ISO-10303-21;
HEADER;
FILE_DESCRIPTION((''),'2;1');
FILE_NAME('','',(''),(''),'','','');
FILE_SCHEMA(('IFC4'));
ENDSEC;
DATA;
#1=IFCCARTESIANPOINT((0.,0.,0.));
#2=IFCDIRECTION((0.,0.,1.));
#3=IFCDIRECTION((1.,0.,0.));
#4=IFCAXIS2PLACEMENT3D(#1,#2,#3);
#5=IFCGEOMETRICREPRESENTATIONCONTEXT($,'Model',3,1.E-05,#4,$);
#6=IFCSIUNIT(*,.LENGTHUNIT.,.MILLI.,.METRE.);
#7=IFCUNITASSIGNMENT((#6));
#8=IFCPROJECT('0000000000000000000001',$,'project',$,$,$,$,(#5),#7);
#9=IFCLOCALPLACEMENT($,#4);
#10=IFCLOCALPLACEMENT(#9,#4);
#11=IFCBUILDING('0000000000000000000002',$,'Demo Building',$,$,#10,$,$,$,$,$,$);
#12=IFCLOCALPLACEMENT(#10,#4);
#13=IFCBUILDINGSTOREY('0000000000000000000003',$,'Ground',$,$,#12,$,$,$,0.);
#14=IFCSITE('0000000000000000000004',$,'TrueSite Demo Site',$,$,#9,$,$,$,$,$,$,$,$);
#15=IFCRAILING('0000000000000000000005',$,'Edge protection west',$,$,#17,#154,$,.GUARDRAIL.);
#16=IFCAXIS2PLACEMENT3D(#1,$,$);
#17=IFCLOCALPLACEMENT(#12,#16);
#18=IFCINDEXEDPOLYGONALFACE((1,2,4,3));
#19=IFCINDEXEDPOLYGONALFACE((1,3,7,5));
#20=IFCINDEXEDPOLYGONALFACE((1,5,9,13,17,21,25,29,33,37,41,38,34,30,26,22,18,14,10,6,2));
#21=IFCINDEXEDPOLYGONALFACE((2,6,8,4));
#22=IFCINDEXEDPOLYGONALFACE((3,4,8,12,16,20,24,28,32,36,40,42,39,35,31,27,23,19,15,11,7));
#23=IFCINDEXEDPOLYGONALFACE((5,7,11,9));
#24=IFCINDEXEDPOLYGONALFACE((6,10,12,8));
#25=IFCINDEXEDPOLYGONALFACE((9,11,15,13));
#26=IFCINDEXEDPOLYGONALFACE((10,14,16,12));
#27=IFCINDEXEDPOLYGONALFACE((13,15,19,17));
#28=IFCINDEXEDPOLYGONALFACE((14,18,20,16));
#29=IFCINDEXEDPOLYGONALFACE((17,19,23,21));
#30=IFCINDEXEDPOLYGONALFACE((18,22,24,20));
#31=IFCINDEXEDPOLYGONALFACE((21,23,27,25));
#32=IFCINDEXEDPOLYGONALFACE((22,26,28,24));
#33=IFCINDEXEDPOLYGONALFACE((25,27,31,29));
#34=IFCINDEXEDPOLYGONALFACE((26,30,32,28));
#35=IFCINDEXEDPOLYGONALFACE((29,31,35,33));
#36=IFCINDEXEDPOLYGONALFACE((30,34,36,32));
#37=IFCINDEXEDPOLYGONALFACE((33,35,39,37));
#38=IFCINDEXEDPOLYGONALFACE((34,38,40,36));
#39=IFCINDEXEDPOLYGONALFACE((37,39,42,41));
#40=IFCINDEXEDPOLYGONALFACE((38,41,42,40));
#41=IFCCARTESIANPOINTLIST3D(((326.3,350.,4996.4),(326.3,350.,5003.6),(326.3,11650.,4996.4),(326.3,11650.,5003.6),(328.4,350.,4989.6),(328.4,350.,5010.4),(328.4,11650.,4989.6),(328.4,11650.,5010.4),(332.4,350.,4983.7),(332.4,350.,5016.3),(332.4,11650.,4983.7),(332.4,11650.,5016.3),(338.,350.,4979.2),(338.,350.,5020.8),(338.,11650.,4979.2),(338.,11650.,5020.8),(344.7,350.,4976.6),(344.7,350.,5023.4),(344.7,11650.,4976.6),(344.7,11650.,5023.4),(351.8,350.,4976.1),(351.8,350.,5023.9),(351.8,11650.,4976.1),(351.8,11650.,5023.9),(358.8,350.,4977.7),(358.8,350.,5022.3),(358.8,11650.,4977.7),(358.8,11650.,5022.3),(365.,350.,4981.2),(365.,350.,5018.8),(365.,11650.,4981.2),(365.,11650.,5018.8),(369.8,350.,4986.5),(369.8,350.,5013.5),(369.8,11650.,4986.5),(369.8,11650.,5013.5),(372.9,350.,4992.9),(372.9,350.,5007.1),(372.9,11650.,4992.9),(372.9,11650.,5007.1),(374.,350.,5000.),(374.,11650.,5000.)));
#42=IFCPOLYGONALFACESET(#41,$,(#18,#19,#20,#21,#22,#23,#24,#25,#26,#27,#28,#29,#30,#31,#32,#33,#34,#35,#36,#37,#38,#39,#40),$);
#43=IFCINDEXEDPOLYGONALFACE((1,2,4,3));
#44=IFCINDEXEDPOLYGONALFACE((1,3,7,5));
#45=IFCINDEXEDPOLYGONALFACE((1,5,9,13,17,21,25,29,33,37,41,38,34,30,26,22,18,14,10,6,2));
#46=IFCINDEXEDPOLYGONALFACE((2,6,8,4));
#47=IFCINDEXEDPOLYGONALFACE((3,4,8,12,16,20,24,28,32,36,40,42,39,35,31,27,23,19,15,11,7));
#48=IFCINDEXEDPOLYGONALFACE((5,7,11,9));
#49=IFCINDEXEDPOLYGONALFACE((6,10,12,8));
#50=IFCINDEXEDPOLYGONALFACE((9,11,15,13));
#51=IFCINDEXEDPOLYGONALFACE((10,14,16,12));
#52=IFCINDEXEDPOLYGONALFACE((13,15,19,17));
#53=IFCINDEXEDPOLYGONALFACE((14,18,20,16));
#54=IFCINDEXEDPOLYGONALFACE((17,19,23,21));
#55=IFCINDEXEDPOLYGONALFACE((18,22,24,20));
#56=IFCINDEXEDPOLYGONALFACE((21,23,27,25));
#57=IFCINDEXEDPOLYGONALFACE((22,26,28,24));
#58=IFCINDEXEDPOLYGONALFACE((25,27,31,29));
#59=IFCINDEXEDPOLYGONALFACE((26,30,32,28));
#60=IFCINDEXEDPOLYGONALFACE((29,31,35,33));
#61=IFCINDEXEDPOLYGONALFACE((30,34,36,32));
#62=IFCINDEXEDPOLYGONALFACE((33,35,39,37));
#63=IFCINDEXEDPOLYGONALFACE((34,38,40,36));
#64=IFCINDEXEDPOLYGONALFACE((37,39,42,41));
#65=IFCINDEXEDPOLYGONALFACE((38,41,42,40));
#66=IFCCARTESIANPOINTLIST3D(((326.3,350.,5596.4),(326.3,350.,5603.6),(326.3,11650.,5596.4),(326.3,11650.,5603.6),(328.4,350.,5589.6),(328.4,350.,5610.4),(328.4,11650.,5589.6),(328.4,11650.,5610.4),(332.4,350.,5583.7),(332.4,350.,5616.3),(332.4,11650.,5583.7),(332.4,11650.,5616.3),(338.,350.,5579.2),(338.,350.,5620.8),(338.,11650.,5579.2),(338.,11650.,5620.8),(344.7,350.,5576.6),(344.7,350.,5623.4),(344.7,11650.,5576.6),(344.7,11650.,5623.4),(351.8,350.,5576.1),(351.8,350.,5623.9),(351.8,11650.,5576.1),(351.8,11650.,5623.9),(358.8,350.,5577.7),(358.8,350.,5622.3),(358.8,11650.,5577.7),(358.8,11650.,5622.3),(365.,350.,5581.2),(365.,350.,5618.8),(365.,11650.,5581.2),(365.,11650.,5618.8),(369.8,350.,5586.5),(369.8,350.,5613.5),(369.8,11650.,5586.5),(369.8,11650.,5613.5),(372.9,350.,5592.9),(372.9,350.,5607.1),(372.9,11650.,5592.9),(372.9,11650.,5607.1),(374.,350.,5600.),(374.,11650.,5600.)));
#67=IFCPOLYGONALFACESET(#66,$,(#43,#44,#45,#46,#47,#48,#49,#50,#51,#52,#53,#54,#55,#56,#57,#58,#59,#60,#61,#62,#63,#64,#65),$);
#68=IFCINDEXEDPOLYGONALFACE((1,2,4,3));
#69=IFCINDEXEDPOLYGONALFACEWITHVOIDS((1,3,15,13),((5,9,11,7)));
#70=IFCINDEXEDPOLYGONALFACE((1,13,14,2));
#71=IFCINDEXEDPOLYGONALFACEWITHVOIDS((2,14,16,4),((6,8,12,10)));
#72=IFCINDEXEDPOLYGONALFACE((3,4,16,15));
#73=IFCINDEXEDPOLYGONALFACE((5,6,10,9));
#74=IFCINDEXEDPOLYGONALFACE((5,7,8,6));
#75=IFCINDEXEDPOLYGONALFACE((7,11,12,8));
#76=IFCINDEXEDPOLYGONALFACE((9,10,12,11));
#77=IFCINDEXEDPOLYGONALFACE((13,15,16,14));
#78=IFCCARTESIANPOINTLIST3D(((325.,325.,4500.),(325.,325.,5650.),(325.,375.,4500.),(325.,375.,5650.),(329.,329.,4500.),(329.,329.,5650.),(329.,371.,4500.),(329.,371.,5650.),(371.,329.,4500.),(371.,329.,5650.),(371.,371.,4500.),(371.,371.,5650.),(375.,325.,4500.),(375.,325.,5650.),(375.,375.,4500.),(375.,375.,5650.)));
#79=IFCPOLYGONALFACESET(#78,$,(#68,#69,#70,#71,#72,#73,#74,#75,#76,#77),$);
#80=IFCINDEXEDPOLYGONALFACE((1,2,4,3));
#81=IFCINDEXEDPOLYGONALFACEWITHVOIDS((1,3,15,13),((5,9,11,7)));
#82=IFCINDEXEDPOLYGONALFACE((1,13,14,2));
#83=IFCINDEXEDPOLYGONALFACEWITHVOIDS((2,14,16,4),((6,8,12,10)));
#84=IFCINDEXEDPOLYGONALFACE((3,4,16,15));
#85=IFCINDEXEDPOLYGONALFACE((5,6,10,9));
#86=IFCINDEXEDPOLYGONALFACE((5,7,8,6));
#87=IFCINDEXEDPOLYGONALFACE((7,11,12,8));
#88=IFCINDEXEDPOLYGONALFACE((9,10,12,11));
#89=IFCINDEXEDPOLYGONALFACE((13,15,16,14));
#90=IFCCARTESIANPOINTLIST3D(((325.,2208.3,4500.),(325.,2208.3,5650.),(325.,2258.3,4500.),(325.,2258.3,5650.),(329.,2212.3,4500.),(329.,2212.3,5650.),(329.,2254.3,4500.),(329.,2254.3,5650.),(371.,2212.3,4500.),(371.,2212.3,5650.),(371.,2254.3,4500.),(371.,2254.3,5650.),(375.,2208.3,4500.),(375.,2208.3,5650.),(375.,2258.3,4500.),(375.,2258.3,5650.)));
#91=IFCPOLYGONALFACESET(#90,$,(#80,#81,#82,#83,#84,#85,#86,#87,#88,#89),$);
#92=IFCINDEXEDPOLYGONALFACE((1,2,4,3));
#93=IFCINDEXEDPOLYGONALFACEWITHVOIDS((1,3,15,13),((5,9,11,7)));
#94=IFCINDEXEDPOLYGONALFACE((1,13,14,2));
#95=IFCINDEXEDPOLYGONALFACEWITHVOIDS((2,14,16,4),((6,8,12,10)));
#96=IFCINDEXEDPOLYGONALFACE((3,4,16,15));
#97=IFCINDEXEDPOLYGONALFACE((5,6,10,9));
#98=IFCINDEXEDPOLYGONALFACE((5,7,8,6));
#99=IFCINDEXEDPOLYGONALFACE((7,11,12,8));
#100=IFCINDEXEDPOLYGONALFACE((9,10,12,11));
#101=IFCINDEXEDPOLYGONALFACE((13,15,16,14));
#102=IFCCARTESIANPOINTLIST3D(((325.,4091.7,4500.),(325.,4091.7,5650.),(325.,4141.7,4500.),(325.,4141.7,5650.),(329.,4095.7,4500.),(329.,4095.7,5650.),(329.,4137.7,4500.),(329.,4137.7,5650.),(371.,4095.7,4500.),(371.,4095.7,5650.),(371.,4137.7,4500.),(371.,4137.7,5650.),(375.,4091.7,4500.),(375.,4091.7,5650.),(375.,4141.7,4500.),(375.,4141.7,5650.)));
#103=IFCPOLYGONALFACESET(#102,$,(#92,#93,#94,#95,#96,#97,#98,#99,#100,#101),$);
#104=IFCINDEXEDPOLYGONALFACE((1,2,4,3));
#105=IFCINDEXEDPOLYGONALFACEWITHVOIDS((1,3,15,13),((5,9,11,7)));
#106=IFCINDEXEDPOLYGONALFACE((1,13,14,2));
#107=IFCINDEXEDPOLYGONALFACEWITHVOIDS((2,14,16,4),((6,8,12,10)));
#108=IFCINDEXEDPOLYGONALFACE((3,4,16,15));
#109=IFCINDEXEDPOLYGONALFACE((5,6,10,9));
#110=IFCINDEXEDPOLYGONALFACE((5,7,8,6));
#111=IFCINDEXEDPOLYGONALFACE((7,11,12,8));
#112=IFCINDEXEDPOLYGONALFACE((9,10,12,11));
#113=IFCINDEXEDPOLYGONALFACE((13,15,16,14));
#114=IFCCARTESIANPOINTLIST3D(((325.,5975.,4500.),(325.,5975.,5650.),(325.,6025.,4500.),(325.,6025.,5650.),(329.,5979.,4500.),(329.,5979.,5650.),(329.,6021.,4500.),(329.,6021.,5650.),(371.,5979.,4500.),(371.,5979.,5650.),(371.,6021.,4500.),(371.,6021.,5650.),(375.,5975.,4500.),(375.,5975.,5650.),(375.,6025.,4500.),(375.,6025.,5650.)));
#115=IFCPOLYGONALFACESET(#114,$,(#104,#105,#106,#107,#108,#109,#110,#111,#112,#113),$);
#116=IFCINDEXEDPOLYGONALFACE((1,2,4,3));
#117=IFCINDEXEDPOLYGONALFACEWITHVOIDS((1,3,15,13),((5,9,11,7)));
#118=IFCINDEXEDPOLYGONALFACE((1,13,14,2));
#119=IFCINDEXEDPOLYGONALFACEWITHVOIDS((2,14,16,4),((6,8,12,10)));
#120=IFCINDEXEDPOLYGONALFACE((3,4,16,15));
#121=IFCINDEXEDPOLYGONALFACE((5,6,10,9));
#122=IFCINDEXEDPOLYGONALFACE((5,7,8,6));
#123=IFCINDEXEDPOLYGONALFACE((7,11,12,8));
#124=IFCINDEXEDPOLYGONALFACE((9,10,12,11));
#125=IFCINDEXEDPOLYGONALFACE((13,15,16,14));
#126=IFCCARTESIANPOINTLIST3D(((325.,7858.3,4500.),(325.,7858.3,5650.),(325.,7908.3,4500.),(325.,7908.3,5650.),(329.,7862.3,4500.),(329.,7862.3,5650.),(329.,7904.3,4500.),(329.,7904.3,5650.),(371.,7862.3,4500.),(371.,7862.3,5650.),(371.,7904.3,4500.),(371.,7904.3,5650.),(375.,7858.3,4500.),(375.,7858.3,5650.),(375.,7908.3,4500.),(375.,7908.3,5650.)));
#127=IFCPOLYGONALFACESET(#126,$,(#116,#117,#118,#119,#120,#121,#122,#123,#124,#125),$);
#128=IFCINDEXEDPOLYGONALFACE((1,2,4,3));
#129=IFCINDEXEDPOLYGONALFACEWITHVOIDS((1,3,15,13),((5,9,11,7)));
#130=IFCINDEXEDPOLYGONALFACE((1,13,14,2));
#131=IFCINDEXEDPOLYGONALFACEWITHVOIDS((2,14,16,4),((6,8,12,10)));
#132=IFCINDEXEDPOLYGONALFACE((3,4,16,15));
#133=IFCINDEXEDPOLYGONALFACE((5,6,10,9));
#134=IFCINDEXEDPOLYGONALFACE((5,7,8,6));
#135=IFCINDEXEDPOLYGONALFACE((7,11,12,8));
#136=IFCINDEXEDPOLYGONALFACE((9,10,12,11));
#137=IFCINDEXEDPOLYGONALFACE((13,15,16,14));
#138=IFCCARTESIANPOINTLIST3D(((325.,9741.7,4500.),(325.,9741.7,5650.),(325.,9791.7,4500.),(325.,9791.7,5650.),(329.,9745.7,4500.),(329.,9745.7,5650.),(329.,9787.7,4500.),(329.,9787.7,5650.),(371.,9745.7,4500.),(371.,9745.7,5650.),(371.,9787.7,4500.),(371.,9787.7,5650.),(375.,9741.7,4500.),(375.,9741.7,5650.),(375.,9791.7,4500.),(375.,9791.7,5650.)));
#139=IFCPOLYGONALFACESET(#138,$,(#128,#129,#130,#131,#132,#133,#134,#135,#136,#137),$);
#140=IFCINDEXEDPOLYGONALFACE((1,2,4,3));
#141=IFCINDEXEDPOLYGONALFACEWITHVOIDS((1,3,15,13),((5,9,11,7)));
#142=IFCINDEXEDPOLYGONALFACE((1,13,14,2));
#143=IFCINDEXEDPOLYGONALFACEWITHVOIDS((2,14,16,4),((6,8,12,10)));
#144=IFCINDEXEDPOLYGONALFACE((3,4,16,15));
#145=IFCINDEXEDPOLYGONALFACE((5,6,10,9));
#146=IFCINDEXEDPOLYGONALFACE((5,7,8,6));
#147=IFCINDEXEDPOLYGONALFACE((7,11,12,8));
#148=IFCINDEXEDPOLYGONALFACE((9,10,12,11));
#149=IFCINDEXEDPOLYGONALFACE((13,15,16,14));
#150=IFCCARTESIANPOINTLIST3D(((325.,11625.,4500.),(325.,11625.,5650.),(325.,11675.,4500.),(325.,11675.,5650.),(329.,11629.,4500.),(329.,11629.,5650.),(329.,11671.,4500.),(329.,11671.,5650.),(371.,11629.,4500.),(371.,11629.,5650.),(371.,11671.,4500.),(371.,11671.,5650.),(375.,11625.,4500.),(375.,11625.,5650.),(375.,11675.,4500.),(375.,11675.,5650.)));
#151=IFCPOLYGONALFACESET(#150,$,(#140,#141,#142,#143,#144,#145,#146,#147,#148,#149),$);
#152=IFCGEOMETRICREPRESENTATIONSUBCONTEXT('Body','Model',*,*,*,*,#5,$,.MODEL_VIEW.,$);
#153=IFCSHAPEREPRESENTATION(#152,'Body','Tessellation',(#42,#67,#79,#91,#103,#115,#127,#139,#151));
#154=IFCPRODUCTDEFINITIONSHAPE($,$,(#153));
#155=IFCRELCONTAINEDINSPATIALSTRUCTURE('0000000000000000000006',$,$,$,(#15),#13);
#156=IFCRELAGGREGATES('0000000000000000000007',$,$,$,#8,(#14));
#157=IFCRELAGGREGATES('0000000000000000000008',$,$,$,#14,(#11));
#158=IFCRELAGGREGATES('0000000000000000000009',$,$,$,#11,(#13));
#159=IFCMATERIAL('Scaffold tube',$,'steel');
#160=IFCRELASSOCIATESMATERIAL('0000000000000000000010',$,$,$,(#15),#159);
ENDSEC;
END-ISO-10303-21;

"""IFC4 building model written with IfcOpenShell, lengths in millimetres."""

from ifc_helpers import new_model, si_unit, frame, origin_with_axes, place, context, subcontext, project, spatial, hollow_rectangle, circle, extrude, material, element, save


model = new_model("IFC4")

# Units and contexts
model_context = context("Model", 3, precision=1e-05, world=origin_with_axes())
body_context = subcontext(model_context, "Body", "Model", "MODEL_VIEW")
ifc_project = project(units=[si_unit("LENGTHUNIT", "METRE", prefix="MILLI")], contexts=[model_context])

# Site, building, storey
site_placement = place(None, origin_with_axes())
site = spatial("IfcSite", under=ifc_project, at=site_placement, Name="TrueSite Demo Site")
building_placement = place(site_placement, origin_with_axes())
building = spatial("IfcBuilding", under=site, at=building_placement, Name="Demo Building")
storey_placement = place(building_placement, origin_with_axes())
storey = spatial("IfcBuildingStorey", under=building, at=storey_placement, Name="Ground", Elevation=0.0)

# Railing
ifc_material_1 = material(Name="Scaffold tube", Category="steel")
railing_1_placement = place(storey_placement, origin_with_axes())
element("IfcRailing", 1, at=railing_1_placement, inside=storey, material=ifc_material_1, Name="Edge protection west", PredefinedType="GUARDRAIL", context=body_context, shape_type="SweptSolid", body=[
    extrude(circle(Radius=24.0), frame((350.0, 350.0, 5000.0), z_axis=(0.0, 1.0, 0.0), x_axis=(1.0, 0.0, 0.0)), (0.0, 0.0, 1.0), 11300.0),
    extrude(circle(Radius=24.0), frame((350.0, 350.0, 5600.0), z_axis=(0.0, 1.0, 0.0), x_axis=(1.0, 0.0, 0.0)), (0.0, 0.0, 1.0), 11300.0),
    extrude(hollow_rectangle(XDim=50.0, YDim=50.0, WallThickness=4.0), frame((350.0, 350.0, 4500.0), z_axis=(0.0, 0.0, 1.0), x_axis=(1.0, 0.0, 0.0)), (0.0, 0.0, 1.0), 1150.0),
    extrude(hollow_rectangle(XDim=50.0, YDim=50.0, WallThickness=4.0), frame((350.0, 2233.3, 4500.0), z_axis=(0.0, 0.0, 1.0), x_axis=(1.0, 0.0, 0.0)), (0.0, 0.0, 1.0), 1150.0),
    extrude(hollow_rectangle(XDim=50.0, YDim=50.0, WallThickness=4.0), frame((350.0, 4116.7, 4500.0), z_axis=(0.0, 0.0, 1.0), x_axis=(1.0, 0.0, 0.0)), (0.0, 0.0, 1.0), 1150.0),
    extrude(hollow_rectangle(XDim=50.0, YDim=50.0, WallThickness=4.0), frame((350.0, 6000.0, 4500.0), z_axis=(0.0, 0.0, 1.0), x_axis=(1.0, 0.0, 0.0)), (0.0, 0.0, 1.0), 1150.0),
    extrude(hollow_rectangle(XDim=50.0, YDim=50.0, WallThickness=4.0), frame((350.0, 7883.3, 4500.0), z_axis=(0.0, 0.0, 1.0), x_axis=(1.0, 0.0, 0.0)), (0.0, 0.0, 1.0), 1150.0),
    extrude(hollow_rectangle(XDim=50.0, YDim=50.0, WallThickness=4.0), frame((350.0, 9766.7, 4500.0), z_axis=(0.0, 0.0, 1.0), x_axis=(1.0, 0.0, 0.0)), (0.0, 0.0, 1.0), 1150.0),
    extrude(hollow_rectangle(XDim=50.0, YDim=50.0, WallThickness=4.0), frame((350.0, 11650.0, 4500.0), z_axis=(0.0, 0.0, 1.0), x_axis=(1.0, 0.0, 0.0)), (0.0, 0.0, 1.0), 1150.0),
])

save(model, "model.ifc")
